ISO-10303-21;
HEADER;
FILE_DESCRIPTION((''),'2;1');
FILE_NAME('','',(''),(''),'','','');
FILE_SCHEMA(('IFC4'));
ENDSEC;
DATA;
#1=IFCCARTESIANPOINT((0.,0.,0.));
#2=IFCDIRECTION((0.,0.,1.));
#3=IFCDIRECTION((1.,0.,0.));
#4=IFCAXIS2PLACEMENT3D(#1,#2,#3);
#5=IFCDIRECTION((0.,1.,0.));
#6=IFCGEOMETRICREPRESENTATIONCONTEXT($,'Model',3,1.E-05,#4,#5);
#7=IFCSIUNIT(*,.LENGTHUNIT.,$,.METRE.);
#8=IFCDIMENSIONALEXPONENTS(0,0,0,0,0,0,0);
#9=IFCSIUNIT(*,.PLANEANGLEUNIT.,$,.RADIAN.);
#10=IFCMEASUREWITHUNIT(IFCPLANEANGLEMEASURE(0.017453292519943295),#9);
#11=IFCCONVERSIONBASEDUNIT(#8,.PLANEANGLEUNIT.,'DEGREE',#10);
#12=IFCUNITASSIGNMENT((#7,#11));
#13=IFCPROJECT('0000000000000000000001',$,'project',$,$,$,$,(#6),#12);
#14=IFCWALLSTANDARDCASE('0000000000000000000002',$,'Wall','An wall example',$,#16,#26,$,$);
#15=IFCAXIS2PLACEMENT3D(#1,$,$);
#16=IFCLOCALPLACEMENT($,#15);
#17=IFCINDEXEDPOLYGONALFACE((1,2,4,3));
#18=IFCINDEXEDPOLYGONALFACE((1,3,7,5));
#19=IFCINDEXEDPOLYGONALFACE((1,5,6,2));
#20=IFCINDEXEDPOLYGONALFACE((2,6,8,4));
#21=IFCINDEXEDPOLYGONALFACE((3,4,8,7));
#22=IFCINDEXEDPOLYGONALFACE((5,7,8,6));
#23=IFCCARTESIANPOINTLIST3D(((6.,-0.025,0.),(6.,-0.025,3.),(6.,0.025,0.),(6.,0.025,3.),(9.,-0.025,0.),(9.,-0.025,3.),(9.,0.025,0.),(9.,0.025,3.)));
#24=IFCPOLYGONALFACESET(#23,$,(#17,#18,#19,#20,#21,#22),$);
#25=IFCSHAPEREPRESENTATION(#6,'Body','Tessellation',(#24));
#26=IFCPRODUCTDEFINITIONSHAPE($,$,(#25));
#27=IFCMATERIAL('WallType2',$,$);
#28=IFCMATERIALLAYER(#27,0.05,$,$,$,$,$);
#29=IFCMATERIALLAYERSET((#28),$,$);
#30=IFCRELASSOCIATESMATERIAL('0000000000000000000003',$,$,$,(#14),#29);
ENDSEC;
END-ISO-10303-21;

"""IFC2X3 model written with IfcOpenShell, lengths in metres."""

from ifc_helpers import new_model, entity, si_unit, converted_unit, direction, frame, origin_with_axes, place, context, project, polyline, outline, extrude, material, layer, layer_set, layer_usage, element, save


model = new_model("IFC2X3")

# Units and contexts
model_context = context("Model", 3, precision=1e-05, world=origin_with_axes(), true_north=direction((0.0, 1.0, 0.0)))
ifc_project = project(units=[si_unit("LENGTHUNIT", "METRE"), converted_unit("PLANEANGLEUNIT", "DEGREE", entity("IfcPlaneAngleMeasure", 0.017453292519943295), si_unit("PLANEANGLEUNIT", "RADIAN"), dimensions=[0, 0, 0, 0, 0, 0, 0])], contexts=[model_context])

# Wall
placement_1 = place(None, origin_with_axes())
placement_2 = place(placement_1, origin_with_axes())
placement_3 = place(placement_2, origin_with_axes())
ifc_material_1 = material(Name="WallType2")
ifc_layer_1 = layer(ifc_material_1, 0.05)
ifc_layer_set_1 = layer_set([ifc_layer_1])
ifc_layer_usage_1 = layer_usage(ifc_layer_set_1, "AXIS2", "POSITIVE", -0.1)
wall_1_placement = place(placement_3, origin_with_axes())
element("IfcWallStandardCase", 1, at=wall_1_placement, material=ifc_layer_usage_1, Name="Wall", Description="An wall example", context=model_context, shape_type="SweptSolid", body=[
    extrude(outline(polyline([(3.0, 0.025, 0.0), (6.0, 0.025, 0.0), (6.0, -0.025, 0.0), (3.0, -0.025, 0.0), (3.0, 0.025, 0.0)])), frame((3.0, 0.0, 0.0), z_axis=(0.0, 0.0, 1.0), x_axis=(1.0, 0.0, 0.0)), (0.0, 0.0, 1.0), 3.0),
])

save(model, "model.ifc")
